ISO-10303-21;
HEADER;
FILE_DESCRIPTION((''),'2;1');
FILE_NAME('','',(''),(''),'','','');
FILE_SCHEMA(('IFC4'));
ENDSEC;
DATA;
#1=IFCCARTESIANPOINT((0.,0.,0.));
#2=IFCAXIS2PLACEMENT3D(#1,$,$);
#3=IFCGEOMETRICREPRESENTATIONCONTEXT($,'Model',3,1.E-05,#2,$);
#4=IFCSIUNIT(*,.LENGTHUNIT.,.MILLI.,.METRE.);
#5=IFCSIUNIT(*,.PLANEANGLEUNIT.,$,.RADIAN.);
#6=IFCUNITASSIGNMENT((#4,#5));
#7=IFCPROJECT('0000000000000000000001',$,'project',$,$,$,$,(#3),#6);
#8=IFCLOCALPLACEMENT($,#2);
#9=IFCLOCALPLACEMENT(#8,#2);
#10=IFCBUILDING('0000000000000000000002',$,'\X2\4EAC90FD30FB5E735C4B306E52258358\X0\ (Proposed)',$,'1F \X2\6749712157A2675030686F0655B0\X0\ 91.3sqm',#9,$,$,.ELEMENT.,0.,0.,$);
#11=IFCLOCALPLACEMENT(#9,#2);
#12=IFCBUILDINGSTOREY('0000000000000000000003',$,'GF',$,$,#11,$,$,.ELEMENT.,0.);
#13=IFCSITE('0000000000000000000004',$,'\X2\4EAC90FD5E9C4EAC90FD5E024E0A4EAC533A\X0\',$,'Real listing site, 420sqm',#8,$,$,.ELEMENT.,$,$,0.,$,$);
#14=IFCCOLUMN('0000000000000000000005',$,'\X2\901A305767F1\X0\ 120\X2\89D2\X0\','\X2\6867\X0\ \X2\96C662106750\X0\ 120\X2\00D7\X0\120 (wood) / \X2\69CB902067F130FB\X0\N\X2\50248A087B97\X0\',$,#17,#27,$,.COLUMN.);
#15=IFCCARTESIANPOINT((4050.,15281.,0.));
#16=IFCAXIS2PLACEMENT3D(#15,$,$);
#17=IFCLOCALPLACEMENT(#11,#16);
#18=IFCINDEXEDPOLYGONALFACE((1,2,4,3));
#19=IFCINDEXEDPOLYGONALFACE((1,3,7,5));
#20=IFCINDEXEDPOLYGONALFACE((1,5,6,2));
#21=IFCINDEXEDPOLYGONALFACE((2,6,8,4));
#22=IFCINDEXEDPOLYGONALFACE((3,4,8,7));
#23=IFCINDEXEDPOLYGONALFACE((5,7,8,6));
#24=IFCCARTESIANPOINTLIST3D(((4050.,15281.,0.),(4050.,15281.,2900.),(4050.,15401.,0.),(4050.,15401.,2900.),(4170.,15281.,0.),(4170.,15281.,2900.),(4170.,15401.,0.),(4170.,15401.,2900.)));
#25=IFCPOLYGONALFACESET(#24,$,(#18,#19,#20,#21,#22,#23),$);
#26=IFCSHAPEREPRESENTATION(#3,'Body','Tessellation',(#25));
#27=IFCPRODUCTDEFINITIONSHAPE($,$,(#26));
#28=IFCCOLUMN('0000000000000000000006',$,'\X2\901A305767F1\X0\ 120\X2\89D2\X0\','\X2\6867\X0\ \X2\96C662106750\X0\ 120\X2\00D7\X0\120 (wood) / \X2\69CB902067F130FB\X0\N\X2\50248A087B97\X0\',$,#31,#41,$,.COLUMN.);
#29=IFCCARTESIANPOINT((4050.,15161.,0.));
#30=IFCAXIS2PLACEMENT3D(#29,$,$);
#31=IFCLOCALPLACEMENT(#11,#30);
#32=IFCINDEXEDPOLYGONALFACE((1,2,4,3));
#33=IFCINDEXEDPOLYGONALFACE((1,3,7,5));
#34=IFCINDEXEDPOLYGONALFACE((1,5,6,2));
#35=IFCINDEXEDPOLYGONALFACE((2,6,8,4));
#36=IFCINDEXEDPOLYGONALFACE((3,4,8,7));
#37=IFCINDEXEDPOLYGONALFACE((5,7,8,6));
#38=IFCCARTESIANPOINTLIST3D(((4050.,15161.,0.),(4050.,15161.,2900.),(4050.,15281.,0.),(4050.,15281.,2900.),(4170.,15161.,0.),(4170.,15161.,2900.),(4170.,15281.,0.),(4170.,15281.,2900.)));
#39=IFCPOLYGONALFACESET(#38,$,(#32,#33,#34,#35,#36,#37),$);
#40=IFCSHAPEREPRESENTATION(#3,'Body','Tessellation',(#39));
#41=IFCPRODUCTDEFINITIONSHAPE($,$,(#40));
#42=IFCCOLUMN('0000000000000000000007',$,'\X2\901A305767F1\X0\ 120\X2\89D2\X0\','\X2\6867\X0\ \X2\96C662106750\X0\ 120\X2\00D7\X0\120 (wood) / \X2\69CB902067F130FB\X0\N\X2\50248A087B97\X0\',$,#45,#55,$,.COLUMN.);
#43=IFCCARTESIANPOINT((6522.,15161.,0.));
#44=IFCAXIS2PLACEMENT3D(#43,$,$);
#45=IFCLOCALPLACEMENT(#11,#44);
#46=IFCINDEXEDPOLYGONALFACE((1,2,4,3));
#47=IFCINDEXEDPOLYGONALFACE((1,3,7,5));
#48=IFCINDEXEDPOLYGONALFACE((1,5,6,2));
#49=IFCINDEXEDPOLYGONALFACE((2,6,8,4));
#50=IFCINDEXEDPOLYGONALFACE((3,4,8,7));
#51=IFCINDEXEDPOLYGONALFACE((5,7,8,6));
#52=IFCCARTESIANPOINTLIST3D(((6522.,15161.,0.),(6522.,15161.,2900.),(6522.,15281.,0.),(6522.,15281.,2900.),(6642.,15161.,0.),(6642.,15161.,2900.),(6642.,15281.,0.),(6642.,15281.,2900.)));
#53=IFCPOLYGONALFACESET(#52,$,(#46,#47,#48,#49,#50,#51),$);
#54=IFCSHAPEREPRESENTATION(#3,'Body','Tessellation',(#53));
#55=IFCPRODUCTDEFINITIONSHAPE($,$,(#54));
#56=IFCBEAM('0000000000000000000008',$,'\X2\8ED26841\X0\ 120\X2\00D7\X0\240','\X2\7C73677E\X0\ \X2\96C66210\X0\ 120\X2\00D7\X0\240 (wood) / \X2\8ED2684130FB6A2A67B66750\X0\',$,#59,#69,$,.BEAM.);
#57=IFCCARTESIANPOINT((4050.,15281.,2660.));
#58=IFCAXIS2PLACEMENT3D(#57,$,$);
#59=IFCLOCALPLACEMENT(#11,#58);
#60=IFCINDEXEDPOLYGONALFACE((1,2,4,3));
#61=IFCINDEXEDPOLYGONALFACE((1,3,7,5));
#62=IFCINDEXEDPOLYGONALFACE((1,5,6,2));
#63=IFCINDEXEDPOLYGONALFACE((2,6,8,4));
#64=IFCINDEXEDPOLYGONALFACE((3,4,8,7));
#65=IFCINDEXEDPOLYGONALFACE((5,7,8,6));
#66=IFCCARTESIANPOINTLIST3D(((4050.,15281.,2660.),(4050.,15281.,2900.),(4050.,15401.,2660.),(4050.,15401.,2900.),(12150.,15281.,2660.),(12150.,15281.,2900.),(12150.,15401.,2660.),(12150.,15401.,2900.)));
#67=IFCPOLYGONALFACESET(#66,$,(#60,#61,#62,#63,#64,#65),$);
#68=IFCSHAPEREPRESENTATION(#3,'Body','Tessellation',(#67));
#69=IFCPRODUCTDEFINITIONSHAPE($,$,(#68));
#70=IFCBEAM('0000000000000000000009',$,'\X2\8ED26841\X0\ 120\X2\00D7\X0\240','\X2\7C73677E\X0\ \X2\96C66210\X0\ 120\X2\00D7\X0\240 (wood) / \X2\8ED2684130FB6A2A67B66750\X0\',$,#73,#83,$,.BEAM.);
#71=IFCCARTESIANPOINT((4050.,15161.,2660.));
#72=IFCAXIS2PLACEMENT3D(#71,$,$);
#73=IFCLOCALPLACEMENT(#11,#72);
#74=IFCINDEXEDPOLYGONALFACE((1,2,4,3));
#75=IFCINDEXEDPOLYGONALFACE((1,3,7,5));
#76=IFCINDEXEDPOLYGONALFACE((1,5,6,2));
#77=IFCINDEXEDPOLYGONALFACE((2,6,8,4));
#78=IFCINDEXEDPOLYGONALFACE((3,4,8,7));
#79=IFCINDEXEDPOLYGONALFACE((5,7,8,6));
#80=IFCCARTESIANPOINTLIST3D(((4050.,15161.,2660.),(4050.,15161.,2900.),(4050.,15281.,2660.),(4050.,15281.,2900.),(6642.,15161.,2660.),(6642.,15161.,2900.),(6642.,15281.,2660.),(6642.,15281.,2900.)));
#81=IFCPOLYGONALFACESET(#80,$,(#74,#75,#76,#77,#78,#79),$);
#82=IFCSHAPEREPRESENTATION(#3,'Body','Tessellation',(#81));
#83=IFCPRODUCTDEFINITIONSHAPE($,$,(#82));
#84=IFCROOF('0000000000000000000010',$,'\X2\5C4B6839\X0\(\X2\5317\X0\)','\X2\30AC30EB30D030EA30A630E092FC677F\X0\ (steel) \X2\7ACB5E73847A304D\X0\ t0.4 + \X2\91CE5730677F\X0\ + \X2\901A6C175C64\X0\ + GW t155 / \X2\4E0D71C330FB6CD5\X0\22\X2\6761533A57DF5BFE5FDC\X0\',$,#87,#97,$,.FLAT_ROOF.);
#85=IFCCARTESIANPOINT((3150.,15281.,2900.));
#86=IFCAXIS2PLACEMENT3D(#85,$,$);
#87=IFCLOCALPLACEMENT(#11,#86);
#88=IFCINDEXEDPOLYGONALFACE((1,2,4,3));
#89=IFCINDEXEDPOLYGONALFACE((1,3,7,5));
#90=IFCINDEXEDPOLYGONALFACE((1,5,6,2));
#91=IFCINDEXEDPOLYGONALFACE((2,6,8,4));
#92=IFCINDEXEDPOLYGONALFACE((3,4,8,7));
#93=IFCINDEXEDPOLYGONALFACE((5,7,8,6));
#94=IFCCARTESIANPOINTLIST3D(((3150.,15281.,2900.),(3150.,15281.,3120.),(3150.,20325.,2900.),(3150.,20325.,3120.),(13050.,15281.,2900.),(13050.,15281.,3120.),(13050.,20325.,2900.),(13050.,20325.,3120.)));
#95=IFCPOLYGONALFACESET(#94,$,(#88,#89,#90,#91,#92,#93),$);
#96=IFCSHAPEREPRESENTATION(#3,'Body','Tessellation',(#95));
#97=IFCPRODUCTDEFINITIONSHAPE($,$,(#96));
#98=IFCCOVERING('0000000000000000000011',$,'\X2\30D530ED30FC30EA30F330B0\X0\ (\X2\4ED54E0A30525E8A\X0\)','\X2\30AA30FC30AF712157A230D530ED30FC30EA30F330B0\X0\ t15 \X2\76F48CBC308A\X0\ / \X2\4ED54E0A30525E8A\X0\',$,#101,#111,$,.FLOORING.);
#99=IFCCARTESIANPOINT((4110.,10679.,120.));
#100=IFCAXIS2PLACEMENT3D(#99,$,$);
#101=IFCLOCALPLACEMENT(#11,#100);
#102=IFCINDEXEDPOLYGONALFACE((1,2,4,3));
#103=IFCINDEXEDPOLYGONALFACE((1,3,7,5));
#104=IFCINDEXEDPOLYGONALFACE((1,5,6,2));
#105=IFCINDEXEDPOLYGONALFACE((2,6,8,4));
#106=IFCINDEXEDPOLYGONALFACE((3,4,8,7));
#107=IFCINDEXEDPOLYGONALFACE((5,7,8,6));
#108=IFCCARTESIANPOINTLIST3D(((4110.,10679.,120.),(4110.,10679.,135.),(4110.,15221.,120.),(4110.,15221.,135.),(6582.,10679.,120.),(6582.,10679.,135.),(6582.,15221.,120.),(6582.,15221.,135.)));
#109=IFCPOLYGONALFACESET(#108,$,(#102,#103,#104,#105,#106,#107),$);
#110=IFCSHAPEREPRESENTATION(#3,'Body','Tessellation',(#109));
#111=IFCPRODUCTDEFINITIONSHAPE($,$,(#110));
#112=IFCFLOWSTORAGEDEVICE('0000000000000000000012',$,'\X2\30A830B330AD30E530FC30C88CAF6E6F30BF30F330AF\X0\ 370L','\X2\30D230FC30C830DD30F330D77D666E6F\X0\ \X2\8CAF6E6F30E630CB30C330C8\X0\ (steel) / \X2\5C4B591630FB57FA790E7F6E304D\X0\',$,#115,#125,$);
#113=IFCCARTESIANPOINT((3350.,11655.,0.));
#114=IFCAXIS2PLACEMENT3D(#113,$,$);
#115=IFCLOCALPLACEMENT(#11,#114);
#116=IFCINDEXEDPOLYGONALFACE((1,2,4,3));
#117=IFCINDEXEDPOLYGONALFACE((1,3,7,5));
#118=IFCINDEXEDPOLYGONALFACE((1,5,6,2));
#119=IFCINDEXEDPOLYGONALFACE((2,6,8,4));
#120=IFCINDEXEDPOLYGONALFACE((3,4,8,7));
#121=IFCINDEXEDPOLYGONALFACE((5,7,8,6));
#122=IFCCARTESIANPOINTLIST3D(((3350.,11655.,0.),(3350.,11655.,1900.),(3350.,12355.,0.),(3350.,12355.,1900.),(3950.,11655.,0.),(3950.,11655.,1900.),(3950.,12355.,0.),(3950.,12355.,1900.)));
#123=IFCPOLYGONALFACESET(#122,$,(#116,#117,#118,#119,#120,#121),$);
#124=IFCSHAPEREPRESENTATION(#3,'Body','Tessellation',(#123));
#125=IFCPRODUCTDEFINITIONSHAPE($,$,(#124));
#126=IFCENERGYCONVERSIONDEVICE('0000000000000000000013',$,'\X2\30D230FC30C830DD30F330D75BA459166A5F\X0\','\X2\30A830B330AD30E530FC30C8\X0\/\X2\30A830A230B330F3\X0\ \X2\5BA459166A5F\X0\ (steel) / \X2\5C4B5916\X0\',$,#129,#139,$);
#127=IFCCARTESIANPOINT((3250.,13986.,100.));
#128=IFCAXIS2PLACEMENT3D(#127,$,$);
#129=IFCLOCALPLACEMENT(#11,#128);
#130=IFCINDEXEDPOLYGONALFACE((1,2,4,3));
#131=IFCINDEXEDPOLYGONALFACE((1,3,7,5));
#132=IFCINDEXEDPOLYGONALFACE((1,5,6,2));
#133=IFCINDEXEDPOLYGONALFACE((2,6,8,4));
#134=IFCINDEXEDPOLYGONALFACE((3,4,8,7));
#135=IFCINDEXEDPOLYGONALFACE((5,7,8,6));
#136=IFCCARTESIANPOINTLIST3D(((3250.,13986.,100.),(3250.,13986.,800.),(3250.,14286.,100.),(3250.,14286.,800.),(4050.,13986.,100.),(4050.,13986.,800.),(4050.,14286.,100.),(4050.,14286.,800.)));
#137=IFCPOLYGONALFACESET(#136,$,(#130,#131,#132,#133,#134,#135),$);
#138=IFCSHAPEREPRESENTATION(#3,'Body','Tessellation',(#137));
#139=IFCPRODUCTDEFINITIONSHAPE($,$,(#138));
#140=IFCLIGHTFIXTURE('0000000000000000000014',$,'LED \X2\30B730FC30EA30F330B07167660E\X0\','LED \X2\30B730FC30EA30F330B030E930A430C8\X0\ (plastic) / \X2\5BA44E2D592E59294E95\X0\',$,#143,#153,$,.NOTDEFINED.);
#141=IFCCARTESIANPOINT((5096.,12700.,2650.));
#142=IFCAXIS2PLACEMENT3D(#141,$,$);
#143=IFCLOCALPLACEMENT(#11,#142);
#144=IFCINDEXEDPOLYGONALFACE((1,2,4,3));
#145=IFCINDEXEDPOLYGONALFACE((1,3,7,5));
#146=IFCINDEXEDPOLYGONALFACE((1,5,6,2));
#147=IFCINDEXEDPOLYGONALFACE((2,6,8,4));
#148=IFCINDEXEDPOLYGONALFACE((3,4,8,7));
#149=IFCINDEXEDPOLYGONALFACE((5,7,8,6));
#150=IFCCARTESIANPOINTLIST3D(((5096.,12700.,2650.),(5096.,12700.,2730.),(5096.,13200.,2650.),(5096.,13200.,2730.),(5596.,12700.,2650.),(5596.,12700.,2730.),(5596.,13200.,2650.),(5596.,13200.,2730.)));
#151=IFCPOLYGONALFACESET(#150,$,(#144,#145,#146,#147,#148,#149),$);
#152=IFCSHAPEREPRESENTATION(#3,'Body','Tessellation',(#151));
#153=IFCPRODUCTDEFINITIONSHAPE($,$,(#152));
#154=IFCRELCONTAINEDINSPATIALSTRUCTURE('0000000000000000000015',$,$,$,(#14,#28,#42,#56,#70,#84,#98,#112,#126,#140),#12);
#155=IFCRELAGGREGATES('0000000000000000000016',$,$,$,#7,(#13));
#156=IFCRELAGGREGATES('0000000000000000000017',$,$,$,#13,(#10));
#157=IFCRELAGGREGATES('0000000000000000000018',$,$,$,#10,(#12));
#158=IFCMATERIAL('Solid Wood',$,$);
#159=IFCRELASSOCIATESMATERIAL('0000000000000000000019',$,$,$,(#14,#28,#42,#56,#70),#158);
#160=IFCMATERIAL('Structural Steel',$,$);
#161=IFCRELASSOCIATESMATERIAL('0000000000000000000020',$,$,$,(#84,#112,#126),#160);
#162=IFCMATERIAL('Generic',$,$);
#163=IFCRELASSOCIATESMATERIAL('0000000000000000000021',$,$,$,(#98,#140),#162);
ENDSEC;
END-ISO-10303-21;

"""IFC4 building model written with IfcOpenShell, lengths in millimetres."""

from ifc_helpers import new_model, si_unit, frame, frame_2d, origin, place, context, project, spatial, rectangle, extrude, material, element, save


model = new_model("IFC4")

# Units and contexts
model_context = context("Model", 3, precision=1e-05, world=origin())
ifc_project = project(units=[si_unit("LENGTHUNIT", "METRE", prefix="MILLI"), si_unit("PLANEANGLEUNIT", "RADIAN")], contexts=[model_context])

# Site, building, storey
site_placement = place(None, origin())
site = spatial("IfcSite", under=ifc_project, at=site_placement, Name="京都府京都市上京区", ObjectType="Real listing site, 420sqm", CompositionType="ELEMENT", RefElevation=0.0)
building_placement = place(site_placement, origin())
building = spatial("IfcBuilding", under=site, at=building_placement, Name="京都・平屋の別荘 (Proposed)", ObjectType="1F 杉無垢材と漆喰 91.3sqm", CompositionType="ELEMENT", ElevationOfRefHeight=0.0, ElevationOfTerrain=0.0)
storey_placement = place(building_placement, origin())
storey = spatial("IfcBuildingStorey", under=building, at=storey_placement, Name="GF", CompositionType="ELEMENT", Elevation=0.0)

# Columns
ifc_material_1 = material(Name="Solid Wood")
column_1_placement = place(storey_placement, frame((4050.0, 15281.0, 0.0)))
element("IfcColumn", 1, at=column_1_placement, inside=storey, material=ifc_material_1, Name="通し柱 120角", Description="桧 集成材 120×120 (wood) / 構造柱・N値計算", PredefinedType="COLUMN", context=model_context, shape_type="SweptSolid", body=[
    extrude(rectangle(XDim=120.0, YDim=120.0, at=frame_2d((60.0, 60.0))), frame((4050.0, 15281.0, 0.0)), (0.0, 0.0, 1.0), 2900.0),
])
column_2_placement = place(storey_placement, frame((4050.0, 15161.0, 0.0)))
element("IfcColumn", 2, at=column_2_placement, inside=storey, material=ifc_material_1, Name="通し柱 120角", Description="桧 集成材 120×120 (wood) / 構造柱・N値計算", PredefinedType="COLUMN", context=model_context, shape_type="SweptSolid", body=[
    extrude(rectangle(XDim=120.0, YDim=120.0, at=frame_2d((60.0, 60.0))), frame((4050.0, 15161.0, 0.0)), (0.0, 0.0, 1.0), 2900.0),
])
column_3_placement = place(storey_placement, frame((6522.0, 15161.0, 0.0)))
element("IfcColumn", 3, at=column_3_placement, inside=storey, material=ifc_material_1, Name="通し柱 120角", Description="桧 集成材 120×120 (wood) / 構造柱・N値計算", PredefinedType="COLUMN", context=model_context, shape_type="SweptSolid", body=[
    extrude(rectangle(XDim=120.0, YDim=120.0, at=frame_2d((60.0, 60.0))), frame((6522.0, 15161.0, 0.0)), (0.0, 0.0, 1.0), 2900.0),
])

# Beams
beam_1_placement = place(storey_placement, frame((4050.0, 15281.0, 2660.0)))
element("IfcBeam", 4, at=beam_1_placement, inside=storey, material=ifc_material_1, Name="軒桁 120×240", Description="米松 集成 120×240 (wood) / 軒桁・横架材", PredefinedType="BEAM", context=model_context, shape_type="SweptSolid", body=[
    extrude(rectangle(XDim=8100.0, YDim=120.0, at=frame_2d((4050.0, 60.0))), frame((4050.0, 15281.0, 2660.0)), (0.0, 0.0, 1.0), 240.0),
])
beam_2_placement = place(storey_placement, frame((4050.0, 15161.0, 2660.0)))
element("IfcBeam", 5, at=beam_2_placement, inside=storey, material=ifc_material_1, Name="軒桁 120×240", Description="米松 集成 120×240 (wood) / 軒桁・横架材", PredefinedType="BEAM", context=model_context, shape_type="SweptSolid", body=[
    extrude(rectangle(XDim=2592.0, YDim=120.0, at=frame_2d((1296.0, 60.0))), frame((4050.0, 15161.0, 2660.0)), (0.0, 0.0, 1.0), 240.0),
])

# Roof
ifc_material_2 = material(Name="Structural Steel")
roof_placement = place(storey_placement, frame((3150.0, 15281.0, 2900.0)))
element("IfcRoof", 6, at=roof_placement, inside=storey, material=ifc_material_2, Name="屋根(北)", Description="ガルバリウム鋼板 (steel) 立平葺き t0.4 + 野地板 + 通気層 + GW t155 / 不燃・法22条区域対応", PredefinedType="FLAT_ROOF", context=model_context, shape_type="SweptSolid", body=[
    extrude(rectangle(XDim=9900.0, YDim=5044.0, at=frame_2d((4950.0, 2522.0))), frame((3150.0, 15281.0, 2900.0)), (0.0, 0.0, 1.0), 220.0),
])

# Covering
ifc_material_3 = material(Name="Generic")
covering_placement = place(storey_placement, frame((4110.0, 10679.0, 120.0)))
element("IfcCovering", 7, at=covering_placement, inside=storey, material=ifc_material_3, Name="フローリング (仕上げ床)", Description="オーク無垢フローリング t15 直貼り / 仕上げ床", PredefinedType="FLOORING", context=model_context, shape_type="SweptSolid", body=[
    extrude(rectangle(XDim=2472.0, YDim=4542.0, at=frame_2d((1236.0, 2271.0))), frame((4110.0, 10679.0, 120.0)), (0.0, 0.0, 1.0), 15.0),
])

# Flow storage device
flow_storage_device_placement = place(storey_placement, frame((3350.0, 11655.0, 0.0)))
element("IfcFlowStorageDevice", 8, at=flow_storage_device_placement, inside=storey, material=ifc_material_2, Name="エコキュート貯湯タンク 370L", Description="ヒートポンプ給湯 貯湯ユニット (steel) / 屋外・基礎置き", context=model_context, shape_type="SweptSolid", body=[
    extrude(rectangle(XDim=600.0, YDim=700.0, at=frame_2d((300.0, 350.0))), frame((3350.0, 11655.0, 0.0)), (0.0, 0.0, 1.0), 1900.0),
])

# Energy conversion device
energy_conversion_device_placement = place(storey_placement, frame((3250.0, 13986.0, 100.0)))
element("IfcEnergyConversionDevice", 9, at=energy_conversion_device_placement, inside=storey, material=ifc_material_2, Name="ヒートポンプ室外機", Description="エコキュート/エアコン 室外機 (steel) / 屋外", context=model_context, shape_type="SweptSolid", body=[
    extrude(rectangle(XDim=800.0, YDim=300.0, at=frame_2d((400.0, 150.0))), frame((3250.0, 13986.0, 100.0)), (0.0, 0.0, 1.0), 700.0),
])

# Light fixture
light_fixture_placement = place(storey_placement, frame((5096.0, 12700.0, 2650.0)))
element("IfcLightFixture", 10, at=light_fixture_placement, inside=storey, material=ifc_material_3, Name="LED シーリング照明", Description="LED シーリングライト (plastic) / 室中央天井", PredefinedType="NOTDEFINED", context=model_context, shape_type="SweptSolid", body=[
    extrude(rectangle(XDim=500.0, YDim=500.0, at=frame_2d((250.0, 250.0))), frame((5096.0, 12700.0, 2650.0)), (0.0, 0.0, 1.0), 80.0),
])

save(model, "model.ifc")
